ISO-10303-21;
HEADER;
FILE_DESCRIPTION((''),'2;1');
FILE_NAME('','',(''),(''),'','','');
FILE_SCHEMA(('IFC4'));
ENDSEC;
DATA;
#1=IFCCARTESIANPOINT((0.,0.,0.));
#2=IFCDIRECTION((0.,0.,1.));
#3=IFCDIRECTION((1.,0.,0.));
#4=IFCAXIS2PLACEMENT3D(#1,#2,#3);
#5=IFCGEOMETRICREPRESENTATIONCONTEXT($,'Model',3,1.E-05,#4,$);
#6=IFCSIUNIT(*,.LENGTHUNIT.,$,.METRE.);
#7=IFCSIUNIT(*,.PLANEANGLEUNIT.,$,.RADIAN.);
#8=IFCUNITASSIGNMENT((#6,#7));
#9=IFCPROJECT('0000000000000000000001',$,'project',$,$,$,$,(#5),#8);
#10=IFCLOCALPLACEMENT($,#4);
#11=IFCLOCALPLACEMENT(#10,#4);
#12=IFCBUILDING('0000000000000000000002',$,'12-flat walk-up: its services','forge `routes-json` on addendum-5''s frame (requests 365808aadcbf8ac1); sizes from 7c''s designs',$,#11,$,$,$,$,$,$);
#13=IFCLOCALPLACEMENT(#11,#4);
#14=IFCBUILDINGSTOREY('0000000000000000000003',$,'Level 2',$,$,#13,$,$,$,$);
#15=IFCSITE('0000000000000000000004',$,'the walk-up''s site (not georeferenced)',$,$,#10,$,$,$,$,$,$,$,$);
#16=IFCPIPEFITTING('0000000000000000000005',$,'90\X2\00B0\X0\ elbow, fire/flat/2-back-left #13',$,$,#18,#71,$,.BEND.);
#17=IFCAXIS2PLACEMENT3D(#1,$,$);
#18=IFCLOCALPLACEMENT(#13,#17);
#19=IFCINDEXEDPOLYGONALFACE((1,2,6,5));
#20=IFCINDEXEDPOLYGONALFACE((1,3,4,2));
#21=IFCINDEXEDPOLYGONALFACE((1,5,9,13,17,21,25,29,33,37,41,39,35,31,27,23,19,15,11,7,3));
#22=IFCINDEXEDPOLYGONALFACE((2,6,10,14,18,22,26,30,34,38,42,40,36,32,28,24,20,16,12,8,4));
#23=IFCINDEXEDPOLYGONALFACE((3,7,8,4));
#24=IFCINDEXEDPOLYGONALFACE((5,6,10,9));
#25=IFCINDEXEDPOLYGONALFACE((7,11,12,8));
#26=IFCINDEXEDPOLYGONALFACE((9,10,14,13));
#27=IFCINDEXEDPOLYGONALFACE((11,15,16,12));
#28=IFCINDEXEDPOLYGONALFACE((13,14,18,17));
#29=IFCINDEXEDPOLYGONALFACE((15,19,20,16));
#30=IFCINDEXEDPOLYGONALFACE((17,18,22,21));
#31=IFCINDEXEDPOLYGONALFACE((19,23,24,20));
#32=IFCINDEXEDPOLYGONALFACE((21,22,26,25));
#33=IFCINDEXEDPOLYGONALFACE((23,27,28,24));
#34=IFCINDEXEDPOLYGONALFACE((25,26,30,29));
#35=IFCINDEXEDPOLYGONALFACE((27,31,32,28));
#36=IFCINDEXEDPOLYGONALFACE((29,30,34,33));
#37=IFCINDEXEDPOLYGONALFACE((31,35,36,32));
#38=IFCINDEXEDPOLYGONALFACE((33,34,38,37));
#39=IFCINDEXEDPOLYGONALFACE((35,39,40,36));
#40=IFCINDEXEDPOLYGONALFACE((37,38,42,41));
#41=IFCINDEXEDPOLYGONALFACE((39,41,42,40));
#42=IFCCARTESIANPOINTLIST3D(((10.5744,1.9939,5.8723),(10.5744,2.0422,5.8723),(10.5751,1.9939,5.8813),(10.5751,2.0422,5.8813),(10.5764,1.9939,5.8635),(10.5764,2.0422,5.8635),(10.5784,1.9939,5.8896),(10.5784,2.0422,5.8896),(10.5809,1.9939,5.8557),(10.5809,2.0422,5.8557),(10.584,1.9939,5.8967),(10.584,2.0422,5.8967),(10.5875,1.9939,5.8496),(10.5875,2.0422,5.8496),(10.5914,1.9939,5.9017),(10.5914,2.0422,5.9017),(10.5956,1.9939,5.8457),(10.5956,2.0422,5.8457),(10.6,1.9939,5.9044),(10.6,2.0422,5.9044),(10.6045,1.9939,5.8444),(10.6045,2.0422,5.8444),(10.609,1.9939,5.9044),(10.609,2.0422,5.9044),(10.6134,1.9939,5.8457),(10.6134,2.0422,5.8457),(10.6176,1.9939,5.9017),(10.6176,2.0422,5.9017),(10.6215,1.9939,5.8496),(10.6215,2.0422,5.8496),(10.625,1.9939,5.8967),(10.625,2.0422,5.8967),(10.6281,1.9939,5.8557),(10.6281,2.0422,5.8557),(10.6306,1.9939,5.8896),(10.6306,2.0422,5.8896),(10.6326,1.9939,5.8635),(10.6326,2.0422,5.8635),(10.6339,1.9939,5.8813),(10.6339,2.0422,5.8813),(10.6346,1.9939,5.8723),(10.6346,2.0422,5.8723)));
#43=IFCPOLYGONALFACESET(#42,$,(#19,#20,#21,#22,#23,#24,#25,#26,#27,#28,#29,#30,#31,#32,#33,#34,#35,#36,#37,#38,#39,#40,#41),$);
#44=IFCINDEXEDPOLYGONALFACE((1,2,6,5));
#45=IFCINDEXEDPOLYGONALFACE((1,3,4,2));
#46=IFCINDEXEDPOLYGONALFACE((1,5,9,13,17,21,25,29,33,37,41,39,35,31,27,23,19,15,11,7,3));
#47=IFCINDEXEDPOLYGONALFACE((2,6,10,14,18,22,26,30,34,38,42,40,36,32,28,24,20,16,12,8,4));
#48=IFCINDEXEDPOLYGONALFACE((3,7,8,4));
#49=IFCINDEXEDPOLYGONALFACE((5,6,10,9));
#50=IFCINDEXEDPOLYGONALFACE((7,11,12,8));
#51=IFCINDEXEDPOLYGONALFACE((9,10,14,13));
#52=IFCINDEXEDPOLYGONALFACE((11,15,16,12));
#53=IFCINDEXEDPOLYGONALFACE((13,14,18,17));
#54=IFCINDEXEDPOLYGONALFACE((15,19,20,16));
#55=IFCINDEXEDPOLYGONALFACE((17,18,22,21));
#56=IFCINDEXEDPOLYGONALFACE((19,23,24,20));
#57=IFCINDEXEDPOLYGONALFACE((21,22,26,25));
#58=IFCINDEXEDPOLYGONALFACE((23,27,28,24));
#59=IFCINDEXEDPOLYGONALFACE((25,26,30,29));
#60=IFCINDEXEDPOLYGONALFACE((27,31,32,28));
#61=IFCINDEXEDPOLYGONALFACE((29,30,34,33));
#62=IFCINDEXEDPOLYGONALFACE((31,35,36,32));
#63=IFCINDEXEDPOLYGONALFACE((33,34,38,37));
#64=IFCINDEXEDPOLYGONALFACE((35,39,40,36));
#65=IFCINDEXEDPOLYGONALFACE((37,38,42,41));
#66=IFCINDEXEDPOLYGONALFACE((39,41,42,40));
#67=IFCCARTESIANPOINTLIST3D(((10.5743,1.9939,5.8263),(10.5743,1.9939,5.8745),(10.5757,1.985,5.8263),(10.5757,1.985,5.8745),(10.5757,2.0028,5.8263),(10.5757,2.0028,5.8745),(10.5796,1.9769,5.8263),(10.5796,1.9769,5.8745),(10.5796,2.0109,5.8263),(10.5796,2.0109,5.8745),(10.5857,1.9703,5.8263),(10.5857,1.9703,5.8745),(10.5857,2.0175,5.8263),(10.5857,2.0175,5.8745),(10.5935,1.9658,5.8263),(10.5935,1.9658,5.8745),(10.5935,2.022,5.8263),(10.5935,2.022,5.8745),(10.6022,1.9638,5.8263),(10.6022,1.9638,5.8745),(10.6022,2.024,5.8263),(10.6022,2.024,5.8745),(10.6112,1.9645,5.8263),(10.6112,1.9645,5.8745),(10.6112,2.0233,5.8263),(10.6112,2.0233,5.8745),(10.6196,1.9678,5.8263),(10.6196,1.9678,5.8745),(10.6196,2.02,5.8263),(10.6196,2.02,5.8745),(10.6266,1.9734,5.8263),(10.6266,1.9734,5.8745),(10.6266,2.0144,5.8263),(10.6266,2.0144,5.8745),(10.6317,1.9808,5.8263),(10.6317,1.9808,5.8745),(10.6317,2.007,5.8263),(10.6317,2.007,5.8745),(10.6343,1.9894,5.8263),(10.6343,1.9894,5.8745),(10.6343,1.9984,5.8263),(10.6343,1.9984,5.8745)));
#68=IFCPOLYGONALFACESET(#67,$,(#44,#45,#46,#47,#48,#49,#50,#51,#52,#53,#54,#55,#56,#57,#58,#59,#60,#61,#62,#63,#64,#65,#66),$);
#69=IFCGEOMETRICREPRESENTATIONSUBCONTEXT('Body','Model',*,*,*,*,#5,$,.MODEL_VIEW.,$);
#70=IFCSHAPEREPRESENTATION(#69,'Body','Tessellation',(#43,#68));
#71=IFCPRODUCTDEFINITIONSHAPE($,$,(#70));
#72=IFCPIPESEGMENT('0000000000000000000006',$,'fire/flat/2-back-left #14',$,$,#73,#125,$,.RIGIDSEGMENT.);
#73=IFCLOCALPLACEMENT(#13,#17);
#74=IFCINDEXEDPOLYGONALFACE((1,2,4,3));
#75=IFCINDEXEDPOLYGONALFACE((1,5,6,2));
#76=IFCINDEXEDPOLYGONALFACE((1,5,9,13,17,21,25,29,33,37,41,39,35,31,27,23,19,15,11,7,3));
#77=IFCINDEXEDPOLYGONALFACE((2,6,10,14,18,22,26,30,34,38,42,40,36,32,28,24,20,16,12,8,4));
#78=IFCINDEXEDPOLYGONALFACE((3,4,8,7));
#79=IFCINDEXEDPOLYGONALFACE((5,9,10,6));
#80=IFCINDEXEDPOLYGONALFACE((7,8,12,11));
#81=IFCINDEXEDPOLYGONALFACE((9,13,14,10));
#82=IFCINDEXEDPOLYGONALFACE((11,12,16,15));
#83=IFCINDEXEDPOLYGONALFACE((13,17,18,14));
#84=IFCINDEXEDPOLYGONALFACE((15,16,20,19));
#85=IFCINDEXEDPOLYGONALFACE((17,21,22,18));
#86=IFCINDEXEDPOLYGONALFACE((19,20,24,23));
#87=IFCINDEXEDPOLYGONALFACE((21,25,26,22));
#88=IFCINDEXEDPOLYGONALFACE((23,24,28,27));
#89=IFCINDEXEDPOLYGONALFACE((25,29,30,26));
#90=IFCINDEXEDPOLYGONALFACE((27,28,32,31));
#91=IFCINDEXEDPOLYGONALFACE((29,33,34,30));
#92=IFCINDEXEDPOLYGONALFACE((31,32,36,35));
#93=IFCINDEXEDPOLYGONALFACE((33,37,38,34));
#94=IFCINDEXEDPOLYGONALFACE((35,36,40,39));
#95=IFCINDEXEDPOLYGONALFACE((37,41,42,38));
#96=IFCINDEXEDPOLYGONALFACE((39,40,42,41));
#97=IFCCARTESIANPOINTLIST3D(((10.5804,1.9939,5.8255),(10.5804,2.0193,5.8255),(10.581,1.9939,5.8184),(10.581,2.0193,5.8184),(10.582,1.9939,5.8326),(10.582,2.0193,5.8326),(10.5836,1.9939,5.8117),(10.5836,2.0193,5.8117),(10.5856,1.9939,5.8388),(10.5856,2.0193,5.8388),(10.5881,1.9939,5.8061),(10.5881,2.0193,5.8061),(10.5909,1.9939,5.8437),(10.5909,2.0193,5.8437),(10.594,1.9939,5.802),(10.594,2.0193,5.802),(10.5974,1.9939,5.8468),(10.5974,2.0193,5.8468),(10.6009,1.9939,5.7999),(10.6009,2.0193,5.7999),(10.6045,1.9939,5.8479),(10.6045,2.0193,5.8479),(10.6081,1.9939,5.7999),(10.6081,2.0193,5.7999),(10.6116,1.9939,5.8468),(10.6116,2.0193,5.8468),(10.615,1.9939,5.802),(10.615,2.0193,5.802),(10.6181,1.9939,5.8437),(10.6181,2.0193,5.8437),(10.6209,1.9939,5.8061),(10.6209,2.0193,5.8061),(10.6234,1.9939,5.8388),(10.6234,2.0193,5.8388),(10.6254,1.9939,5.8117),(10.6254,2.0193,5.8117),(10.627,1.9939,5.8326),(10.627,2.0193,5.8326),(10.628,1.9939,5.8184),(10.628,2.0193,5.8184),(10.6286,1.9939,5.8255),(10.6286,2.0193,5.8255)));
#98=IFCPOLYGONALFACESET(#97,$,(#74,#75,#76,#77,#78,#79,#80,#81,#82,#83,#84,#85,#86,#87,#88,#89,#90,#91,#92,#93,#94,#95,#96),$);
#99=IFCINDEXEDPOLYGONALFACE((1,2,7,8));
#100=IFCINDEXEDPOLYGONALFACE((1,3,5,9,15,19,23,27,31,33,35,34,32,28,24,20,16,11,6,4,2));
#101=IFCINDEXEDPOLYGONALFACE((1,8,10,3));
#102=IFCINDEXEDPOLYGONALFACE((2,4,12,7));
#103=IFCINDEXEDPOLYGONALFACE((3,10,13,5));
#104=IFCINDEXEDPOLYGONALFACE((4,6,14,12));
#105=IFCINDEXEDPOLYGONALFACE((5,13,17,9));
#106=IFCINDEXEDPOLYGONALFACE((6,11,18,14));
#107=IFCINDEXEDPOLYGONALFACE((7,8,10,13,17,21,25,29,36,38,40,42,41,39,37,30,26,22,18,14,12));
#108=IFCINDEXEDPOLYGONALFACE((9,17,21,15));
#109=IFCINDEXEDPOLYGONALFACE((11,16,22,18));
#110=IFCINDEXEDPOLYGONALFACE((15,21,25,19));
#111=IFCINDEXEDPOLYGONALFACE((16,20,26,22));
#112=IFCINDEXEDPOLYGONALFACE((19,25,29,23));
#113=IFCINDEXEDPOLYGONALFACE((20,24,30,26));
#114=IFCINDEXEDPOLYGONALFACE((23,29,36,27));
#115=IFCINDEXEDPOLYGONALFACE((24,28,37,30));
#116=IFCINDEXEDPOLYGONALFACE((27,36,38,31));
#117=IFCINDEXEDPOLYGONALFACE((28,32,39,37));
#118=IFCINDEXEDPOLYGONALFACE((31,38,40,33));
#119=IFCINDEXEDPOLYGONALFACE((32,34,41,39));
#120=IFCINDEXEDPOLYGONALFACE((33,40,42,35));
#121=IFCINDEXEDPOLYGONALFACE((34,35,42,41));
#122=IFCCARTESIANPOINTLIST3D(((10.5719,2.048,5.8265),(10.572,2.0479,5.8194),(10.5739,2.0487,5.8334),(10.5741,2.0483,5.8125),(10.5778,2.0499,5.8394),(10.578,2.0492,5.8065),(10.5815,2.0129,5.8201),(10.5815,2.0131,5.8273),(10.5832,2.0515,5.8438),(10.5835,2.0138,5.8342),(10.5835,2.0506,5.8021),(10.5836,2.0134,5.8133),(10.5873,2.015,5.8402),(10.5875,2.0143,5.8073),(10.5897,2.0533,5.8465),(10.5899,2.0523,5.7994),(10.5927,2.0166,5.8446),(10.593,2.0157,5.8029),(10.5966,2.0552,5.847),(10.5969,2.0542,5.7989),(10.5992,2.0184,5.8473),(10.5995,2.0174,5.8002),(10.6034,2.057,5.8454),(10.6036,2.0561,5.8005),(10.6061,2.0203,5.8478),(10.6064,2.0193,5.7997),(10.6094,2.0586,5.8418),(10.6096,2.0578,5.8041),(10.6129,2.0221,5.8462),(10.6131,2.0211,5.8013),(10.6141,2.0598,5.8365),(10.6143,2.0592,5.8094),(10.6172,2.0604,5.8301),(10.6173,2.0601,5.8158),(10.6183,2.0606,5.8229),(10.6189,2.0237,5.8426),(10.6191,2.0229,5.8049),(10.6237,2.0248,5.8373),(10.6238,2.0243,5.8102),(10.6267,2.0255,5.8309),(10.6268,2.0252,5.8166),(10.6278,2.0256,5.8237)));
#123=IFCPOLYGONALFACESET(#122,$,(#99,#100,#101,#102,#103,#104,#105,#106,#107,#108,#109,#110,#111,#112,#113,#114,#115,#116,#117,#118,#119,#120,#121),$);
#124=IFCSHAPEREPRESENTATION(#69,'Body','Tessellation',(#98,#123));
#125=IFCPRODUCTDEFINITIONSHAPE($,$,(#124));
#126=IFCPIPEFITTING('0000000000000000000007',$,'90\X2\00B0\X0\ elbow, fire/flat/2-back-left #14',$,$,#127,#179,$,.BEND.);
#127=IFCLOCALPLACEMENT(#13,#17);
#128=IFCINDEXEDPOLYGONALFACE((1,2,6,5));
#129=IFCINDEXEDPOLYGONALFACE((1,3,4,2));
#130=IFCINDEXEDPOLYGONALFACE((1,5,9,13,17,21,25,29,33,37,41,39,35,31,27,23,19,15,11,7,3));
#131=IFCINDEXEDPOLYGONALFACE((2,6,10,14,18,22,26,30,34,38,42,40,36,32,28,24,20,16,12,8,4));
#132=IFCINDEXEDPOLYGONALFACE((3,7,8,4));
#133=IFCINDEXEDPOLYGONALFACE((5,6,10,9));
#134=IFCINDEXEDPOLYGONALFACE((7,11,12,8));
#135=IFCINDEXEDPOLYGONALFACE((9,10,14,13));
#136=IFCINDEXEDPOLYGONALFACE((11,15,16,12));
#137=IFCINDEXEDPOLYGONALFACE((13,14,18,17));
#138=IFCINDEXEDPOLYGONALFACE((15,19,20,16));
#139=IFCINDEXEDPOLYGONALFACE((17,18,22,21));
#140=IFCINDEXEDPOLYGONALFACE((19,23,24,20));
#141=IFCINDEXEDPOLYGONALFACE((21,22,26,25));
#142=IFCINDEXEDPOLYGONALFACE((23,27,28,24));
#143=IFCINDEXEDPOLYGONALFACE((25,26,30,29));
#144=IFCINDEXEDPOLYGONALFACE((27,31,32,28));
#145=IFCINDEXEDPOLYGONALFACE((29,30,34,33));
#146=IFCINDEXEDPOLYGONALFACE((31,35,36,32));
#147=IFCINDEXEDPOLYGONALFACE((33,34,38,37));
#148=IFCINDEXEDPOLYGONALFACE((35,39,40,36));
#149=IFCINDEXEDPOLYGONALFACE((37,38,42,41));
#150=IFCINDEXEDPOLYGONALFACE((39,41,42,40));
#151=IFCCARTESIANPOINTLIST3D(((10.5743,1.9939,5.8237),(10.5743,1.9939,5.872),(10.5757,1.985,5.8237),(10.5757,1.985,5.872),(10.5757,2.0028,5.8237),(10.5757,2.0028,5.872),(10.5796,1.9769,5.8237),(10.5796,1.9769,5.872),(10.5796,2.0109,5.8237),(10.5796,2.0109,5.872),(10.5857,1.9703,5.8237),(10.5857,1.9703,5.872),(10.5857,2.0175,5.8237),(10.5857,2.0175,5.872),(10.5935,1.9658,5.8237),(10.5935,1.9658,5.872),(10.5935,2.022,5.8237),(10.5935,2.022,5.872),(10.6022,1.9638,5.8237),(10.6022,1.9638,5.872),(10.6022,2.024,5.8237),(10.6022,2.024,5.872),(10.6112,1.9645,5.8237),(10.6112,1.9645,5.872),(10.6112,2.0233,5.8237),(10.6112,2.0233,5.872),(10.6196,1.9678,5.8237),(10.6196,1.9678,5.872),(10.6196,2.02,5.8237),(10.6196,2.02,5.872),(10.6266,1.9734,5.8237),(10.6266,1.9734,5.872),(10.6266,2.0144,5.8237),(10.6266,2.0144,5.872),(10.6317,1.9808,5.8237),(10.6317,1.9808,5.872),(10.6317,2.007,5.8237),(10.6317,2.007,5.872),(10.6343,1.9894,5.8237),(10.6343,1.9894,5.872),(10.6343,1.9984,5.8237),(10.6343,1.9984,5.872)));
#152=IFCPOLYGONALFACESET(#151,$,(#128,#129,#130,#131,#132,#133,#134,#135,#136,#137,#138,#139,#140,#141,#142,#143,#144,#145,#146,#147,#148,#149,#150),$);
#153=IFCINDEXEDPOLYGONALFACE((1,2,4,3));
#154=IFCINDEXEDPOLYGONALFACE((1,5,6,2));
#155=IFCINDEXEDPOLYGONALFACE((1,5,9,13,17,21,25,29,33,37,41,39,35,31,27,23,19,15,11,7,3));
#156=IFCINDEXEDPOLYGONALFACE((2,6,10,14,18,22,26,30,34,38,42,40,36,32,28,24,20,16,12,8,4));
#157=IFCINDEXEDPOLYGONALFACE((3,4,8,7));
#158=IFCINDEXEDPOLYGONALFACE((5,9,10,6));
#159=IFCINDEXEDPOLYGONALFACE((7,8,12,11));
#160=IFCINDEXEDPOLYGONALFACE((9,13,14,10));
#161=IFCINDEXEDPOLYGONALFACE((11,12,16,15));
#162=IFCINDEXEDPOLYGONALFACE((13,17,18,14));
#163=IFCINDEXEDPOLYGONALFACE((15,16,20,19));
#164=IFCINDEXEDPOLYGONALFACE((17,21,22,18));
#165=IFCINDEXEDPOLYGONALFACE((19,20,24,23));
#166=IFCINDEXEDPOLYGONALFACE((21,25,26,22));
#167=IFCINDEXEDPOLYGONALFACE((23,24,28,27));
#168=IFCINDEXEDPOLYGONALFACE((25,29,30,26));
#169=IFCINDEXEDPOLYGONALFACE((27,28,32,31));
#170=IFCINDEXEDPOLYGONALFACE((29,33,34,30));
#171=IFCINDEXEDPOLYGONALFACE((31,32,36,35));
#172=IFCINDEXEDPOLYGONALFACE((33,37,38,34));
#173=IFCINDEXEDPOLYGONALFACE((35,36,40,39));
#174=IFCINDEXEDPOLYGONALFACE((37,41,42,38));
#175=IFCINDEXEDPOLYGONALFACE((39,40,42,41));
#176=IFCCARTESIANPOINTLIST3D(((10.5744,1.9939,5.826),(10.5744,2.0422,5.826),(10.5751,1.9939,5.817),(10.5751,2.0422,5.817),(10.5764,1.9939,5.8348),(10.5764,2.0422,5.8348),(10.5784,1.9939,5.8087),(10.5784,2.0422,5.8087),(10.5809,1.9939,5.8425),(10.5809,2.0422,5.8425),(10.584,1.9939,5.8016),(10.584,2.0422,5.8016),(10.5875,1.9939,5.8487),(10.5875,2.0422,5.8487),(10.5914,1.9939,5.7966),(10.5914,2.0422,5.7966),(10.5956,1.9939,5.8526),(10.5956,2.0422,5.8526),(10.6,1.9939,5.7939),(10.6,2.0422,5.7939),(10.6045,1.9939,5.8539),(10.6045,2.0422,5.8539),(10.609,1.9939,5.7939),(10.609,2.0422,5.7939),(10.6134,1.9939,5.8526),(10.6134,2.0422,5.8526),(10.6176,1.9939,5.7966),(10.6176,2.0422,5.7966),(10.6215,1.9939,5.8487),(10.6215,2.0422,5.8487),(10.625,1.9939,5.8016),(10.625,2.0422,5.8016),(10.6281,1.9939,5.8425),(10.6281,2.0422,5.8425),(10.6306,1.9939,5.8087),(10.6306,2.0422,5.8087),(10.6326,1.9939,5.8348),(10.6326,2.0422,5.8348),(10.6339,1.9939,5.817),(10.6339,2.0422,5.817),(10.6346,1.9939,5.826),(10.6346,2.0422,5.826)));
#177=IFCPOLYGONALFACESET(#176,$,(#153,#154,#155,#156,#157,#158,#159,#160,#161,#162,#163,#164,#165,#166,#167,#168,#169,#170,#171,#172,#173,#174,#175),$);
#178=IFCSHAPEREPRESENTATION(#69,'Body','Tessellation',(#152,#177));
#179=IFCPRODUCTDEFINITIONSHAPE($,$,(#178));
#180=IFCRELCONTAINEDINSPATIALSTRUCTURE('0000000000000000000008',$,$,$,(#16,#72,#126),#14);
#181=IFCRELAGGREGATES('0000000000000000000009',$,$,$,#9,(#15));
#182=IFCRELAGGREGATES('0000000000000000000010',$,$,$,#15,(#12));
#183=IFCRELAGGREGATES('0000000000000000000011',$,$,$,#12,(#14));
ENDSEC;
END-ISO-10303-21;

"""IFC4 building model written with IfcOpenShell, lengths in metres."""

from ifc_helpers import new_model, entity, si_unit, frame, origin_with_axes, place, context, subcontext, project, spatial, element, save


model = new_model("IFC4")

# Units and contexts
model_context = context("Model", 3, precision=1e-05, world=origin_with_axes())
body_context = subcontext(model_context, "Body", "Model", "MODEL_VIEW")
ifc_project = project(units=[si_unit("LENGTHUNIT", "METRE"), si_unit("PLANEANGLEUNIT", "RADIAN")], contexts=[model_context])

# Site, building, storey
site_placement = place(None, origin_with_axes())
site = spatial("IfcSite", under=ifc_project, at=site_placement, Name="the walk-up's site (not georeferenced)")
building_placement = place(site_placement, origin_with_axes())
building = spatial("IfcBuilding", under=site, at=building_placement, Name="12-flat walk-up: its services", Description="forge `routes-json` on addendum-5's frame (requests 365808aadcbf8ac1); sizes from 7c's designs")
storey_placement = place(building_placement, origin_with_axes())
storey = spatial("IfcBuildingStorey", under=building, at=storey_placement, Name="Level 2")

# Pipe fitting
pipe_fitting_1_placement = place(storey_placement, frame((10.6045, 2.0422, 5.8745), z_axis=(0.0, 0.0, 1.0), x_axis=(1.0, 0.0, 0.0)))
element("IfcPipeFitting", 1, at=pipe_fitting_1_placement, inside=storey, Name="90° elbow, fire/flat/2-back-left #13", PredefinedType="BEND", context=body_context, shape_type="AdvancedSweptSolid", body=[
    entity("IfcSweptDiskSolid", entity("IfcPolyline", [entity("IfcCartesianPoint", [0.0, 0.0, 0.0]), entity("IfcCartesianPoint", [0.0, -0.0483, 0.0])]), 0.0302),
    entity("IfcSweptDiskSolid", entity("IfcPolyline", [entity("IfcCartesianPoint", [0.0, -0.0483, 0.0]), entity("IfcCartesianPoint", [0.0, -0.0483, -0.0483])]), 0.0302),
])

# Pipe segment
pipe_segment_1_placement = place(storey_placement, frame((10.6045, 1.9939, 5.8237), z_axis=(0.0, 0.0, 1.0), x_axis=(1.0, 0.0, 0.0)))
element("IfcPipeSegment", 2, at=pipe_segment_1_placement, inside=storey, Name="fire/flat/2-back-left #14", PredefinedType="RIGIDSEGMENT", context=body_context, shape_type="AdvancedSweptSolid", body=[
    entity("IfcSweptDiskSolid", entity("IfcPolyline", [entity("IfcCartesianPoint", [0.0, 0.0, 0.0]), entity("IfcCartesianPoint", [0.0, 0.0254, 0.0])]), 0.0241),
    entity("IfcSweptDiskSolid", entity("IfcPolyline", [entity("IfcCartesianPoint", [0.0, 0.0254, 0.0]), entity("IfcCartesianPoint", [-0.0095, 0.0603, -0.0008])]), 0.0241),
])

# Pipe fitting
pipe_fitting_2_placement = place(storey_placement, frame((10.6045, 1.9939, 5.872), z_axis=(0.0, 0.0, 1.0), x_axis=(1.0, 0.0, 0.0)))
element("IfcPipeFitting", 3, at=pipe_fitting_2_placement, inside=storey, Name="90° elbow, fire/flat/2-back-left #14", PredefinedType="BEND", context=body_context, shape_type="AdvancedSweptSolid", body=[
    entity("IfcSweptDiskSolid", entity("IfcPolyline", [entity("IfcCartesianPoint", [0.0, 0.0, 0.0]), entity("IfcCartesianPoint", [0.0, 0.0, -0.0483])]), 0.0302),
    entity("IfcSweptDiskSolid", entity("IfcPolyline", [entity("IfcCartesianPoint", [0.0, 0.0, -0.0483]), entity("IfcCartesianPoint", [0.0, 0.0483, -0.0483])]), 0.0302),
])

save(model, "model.ifc")
